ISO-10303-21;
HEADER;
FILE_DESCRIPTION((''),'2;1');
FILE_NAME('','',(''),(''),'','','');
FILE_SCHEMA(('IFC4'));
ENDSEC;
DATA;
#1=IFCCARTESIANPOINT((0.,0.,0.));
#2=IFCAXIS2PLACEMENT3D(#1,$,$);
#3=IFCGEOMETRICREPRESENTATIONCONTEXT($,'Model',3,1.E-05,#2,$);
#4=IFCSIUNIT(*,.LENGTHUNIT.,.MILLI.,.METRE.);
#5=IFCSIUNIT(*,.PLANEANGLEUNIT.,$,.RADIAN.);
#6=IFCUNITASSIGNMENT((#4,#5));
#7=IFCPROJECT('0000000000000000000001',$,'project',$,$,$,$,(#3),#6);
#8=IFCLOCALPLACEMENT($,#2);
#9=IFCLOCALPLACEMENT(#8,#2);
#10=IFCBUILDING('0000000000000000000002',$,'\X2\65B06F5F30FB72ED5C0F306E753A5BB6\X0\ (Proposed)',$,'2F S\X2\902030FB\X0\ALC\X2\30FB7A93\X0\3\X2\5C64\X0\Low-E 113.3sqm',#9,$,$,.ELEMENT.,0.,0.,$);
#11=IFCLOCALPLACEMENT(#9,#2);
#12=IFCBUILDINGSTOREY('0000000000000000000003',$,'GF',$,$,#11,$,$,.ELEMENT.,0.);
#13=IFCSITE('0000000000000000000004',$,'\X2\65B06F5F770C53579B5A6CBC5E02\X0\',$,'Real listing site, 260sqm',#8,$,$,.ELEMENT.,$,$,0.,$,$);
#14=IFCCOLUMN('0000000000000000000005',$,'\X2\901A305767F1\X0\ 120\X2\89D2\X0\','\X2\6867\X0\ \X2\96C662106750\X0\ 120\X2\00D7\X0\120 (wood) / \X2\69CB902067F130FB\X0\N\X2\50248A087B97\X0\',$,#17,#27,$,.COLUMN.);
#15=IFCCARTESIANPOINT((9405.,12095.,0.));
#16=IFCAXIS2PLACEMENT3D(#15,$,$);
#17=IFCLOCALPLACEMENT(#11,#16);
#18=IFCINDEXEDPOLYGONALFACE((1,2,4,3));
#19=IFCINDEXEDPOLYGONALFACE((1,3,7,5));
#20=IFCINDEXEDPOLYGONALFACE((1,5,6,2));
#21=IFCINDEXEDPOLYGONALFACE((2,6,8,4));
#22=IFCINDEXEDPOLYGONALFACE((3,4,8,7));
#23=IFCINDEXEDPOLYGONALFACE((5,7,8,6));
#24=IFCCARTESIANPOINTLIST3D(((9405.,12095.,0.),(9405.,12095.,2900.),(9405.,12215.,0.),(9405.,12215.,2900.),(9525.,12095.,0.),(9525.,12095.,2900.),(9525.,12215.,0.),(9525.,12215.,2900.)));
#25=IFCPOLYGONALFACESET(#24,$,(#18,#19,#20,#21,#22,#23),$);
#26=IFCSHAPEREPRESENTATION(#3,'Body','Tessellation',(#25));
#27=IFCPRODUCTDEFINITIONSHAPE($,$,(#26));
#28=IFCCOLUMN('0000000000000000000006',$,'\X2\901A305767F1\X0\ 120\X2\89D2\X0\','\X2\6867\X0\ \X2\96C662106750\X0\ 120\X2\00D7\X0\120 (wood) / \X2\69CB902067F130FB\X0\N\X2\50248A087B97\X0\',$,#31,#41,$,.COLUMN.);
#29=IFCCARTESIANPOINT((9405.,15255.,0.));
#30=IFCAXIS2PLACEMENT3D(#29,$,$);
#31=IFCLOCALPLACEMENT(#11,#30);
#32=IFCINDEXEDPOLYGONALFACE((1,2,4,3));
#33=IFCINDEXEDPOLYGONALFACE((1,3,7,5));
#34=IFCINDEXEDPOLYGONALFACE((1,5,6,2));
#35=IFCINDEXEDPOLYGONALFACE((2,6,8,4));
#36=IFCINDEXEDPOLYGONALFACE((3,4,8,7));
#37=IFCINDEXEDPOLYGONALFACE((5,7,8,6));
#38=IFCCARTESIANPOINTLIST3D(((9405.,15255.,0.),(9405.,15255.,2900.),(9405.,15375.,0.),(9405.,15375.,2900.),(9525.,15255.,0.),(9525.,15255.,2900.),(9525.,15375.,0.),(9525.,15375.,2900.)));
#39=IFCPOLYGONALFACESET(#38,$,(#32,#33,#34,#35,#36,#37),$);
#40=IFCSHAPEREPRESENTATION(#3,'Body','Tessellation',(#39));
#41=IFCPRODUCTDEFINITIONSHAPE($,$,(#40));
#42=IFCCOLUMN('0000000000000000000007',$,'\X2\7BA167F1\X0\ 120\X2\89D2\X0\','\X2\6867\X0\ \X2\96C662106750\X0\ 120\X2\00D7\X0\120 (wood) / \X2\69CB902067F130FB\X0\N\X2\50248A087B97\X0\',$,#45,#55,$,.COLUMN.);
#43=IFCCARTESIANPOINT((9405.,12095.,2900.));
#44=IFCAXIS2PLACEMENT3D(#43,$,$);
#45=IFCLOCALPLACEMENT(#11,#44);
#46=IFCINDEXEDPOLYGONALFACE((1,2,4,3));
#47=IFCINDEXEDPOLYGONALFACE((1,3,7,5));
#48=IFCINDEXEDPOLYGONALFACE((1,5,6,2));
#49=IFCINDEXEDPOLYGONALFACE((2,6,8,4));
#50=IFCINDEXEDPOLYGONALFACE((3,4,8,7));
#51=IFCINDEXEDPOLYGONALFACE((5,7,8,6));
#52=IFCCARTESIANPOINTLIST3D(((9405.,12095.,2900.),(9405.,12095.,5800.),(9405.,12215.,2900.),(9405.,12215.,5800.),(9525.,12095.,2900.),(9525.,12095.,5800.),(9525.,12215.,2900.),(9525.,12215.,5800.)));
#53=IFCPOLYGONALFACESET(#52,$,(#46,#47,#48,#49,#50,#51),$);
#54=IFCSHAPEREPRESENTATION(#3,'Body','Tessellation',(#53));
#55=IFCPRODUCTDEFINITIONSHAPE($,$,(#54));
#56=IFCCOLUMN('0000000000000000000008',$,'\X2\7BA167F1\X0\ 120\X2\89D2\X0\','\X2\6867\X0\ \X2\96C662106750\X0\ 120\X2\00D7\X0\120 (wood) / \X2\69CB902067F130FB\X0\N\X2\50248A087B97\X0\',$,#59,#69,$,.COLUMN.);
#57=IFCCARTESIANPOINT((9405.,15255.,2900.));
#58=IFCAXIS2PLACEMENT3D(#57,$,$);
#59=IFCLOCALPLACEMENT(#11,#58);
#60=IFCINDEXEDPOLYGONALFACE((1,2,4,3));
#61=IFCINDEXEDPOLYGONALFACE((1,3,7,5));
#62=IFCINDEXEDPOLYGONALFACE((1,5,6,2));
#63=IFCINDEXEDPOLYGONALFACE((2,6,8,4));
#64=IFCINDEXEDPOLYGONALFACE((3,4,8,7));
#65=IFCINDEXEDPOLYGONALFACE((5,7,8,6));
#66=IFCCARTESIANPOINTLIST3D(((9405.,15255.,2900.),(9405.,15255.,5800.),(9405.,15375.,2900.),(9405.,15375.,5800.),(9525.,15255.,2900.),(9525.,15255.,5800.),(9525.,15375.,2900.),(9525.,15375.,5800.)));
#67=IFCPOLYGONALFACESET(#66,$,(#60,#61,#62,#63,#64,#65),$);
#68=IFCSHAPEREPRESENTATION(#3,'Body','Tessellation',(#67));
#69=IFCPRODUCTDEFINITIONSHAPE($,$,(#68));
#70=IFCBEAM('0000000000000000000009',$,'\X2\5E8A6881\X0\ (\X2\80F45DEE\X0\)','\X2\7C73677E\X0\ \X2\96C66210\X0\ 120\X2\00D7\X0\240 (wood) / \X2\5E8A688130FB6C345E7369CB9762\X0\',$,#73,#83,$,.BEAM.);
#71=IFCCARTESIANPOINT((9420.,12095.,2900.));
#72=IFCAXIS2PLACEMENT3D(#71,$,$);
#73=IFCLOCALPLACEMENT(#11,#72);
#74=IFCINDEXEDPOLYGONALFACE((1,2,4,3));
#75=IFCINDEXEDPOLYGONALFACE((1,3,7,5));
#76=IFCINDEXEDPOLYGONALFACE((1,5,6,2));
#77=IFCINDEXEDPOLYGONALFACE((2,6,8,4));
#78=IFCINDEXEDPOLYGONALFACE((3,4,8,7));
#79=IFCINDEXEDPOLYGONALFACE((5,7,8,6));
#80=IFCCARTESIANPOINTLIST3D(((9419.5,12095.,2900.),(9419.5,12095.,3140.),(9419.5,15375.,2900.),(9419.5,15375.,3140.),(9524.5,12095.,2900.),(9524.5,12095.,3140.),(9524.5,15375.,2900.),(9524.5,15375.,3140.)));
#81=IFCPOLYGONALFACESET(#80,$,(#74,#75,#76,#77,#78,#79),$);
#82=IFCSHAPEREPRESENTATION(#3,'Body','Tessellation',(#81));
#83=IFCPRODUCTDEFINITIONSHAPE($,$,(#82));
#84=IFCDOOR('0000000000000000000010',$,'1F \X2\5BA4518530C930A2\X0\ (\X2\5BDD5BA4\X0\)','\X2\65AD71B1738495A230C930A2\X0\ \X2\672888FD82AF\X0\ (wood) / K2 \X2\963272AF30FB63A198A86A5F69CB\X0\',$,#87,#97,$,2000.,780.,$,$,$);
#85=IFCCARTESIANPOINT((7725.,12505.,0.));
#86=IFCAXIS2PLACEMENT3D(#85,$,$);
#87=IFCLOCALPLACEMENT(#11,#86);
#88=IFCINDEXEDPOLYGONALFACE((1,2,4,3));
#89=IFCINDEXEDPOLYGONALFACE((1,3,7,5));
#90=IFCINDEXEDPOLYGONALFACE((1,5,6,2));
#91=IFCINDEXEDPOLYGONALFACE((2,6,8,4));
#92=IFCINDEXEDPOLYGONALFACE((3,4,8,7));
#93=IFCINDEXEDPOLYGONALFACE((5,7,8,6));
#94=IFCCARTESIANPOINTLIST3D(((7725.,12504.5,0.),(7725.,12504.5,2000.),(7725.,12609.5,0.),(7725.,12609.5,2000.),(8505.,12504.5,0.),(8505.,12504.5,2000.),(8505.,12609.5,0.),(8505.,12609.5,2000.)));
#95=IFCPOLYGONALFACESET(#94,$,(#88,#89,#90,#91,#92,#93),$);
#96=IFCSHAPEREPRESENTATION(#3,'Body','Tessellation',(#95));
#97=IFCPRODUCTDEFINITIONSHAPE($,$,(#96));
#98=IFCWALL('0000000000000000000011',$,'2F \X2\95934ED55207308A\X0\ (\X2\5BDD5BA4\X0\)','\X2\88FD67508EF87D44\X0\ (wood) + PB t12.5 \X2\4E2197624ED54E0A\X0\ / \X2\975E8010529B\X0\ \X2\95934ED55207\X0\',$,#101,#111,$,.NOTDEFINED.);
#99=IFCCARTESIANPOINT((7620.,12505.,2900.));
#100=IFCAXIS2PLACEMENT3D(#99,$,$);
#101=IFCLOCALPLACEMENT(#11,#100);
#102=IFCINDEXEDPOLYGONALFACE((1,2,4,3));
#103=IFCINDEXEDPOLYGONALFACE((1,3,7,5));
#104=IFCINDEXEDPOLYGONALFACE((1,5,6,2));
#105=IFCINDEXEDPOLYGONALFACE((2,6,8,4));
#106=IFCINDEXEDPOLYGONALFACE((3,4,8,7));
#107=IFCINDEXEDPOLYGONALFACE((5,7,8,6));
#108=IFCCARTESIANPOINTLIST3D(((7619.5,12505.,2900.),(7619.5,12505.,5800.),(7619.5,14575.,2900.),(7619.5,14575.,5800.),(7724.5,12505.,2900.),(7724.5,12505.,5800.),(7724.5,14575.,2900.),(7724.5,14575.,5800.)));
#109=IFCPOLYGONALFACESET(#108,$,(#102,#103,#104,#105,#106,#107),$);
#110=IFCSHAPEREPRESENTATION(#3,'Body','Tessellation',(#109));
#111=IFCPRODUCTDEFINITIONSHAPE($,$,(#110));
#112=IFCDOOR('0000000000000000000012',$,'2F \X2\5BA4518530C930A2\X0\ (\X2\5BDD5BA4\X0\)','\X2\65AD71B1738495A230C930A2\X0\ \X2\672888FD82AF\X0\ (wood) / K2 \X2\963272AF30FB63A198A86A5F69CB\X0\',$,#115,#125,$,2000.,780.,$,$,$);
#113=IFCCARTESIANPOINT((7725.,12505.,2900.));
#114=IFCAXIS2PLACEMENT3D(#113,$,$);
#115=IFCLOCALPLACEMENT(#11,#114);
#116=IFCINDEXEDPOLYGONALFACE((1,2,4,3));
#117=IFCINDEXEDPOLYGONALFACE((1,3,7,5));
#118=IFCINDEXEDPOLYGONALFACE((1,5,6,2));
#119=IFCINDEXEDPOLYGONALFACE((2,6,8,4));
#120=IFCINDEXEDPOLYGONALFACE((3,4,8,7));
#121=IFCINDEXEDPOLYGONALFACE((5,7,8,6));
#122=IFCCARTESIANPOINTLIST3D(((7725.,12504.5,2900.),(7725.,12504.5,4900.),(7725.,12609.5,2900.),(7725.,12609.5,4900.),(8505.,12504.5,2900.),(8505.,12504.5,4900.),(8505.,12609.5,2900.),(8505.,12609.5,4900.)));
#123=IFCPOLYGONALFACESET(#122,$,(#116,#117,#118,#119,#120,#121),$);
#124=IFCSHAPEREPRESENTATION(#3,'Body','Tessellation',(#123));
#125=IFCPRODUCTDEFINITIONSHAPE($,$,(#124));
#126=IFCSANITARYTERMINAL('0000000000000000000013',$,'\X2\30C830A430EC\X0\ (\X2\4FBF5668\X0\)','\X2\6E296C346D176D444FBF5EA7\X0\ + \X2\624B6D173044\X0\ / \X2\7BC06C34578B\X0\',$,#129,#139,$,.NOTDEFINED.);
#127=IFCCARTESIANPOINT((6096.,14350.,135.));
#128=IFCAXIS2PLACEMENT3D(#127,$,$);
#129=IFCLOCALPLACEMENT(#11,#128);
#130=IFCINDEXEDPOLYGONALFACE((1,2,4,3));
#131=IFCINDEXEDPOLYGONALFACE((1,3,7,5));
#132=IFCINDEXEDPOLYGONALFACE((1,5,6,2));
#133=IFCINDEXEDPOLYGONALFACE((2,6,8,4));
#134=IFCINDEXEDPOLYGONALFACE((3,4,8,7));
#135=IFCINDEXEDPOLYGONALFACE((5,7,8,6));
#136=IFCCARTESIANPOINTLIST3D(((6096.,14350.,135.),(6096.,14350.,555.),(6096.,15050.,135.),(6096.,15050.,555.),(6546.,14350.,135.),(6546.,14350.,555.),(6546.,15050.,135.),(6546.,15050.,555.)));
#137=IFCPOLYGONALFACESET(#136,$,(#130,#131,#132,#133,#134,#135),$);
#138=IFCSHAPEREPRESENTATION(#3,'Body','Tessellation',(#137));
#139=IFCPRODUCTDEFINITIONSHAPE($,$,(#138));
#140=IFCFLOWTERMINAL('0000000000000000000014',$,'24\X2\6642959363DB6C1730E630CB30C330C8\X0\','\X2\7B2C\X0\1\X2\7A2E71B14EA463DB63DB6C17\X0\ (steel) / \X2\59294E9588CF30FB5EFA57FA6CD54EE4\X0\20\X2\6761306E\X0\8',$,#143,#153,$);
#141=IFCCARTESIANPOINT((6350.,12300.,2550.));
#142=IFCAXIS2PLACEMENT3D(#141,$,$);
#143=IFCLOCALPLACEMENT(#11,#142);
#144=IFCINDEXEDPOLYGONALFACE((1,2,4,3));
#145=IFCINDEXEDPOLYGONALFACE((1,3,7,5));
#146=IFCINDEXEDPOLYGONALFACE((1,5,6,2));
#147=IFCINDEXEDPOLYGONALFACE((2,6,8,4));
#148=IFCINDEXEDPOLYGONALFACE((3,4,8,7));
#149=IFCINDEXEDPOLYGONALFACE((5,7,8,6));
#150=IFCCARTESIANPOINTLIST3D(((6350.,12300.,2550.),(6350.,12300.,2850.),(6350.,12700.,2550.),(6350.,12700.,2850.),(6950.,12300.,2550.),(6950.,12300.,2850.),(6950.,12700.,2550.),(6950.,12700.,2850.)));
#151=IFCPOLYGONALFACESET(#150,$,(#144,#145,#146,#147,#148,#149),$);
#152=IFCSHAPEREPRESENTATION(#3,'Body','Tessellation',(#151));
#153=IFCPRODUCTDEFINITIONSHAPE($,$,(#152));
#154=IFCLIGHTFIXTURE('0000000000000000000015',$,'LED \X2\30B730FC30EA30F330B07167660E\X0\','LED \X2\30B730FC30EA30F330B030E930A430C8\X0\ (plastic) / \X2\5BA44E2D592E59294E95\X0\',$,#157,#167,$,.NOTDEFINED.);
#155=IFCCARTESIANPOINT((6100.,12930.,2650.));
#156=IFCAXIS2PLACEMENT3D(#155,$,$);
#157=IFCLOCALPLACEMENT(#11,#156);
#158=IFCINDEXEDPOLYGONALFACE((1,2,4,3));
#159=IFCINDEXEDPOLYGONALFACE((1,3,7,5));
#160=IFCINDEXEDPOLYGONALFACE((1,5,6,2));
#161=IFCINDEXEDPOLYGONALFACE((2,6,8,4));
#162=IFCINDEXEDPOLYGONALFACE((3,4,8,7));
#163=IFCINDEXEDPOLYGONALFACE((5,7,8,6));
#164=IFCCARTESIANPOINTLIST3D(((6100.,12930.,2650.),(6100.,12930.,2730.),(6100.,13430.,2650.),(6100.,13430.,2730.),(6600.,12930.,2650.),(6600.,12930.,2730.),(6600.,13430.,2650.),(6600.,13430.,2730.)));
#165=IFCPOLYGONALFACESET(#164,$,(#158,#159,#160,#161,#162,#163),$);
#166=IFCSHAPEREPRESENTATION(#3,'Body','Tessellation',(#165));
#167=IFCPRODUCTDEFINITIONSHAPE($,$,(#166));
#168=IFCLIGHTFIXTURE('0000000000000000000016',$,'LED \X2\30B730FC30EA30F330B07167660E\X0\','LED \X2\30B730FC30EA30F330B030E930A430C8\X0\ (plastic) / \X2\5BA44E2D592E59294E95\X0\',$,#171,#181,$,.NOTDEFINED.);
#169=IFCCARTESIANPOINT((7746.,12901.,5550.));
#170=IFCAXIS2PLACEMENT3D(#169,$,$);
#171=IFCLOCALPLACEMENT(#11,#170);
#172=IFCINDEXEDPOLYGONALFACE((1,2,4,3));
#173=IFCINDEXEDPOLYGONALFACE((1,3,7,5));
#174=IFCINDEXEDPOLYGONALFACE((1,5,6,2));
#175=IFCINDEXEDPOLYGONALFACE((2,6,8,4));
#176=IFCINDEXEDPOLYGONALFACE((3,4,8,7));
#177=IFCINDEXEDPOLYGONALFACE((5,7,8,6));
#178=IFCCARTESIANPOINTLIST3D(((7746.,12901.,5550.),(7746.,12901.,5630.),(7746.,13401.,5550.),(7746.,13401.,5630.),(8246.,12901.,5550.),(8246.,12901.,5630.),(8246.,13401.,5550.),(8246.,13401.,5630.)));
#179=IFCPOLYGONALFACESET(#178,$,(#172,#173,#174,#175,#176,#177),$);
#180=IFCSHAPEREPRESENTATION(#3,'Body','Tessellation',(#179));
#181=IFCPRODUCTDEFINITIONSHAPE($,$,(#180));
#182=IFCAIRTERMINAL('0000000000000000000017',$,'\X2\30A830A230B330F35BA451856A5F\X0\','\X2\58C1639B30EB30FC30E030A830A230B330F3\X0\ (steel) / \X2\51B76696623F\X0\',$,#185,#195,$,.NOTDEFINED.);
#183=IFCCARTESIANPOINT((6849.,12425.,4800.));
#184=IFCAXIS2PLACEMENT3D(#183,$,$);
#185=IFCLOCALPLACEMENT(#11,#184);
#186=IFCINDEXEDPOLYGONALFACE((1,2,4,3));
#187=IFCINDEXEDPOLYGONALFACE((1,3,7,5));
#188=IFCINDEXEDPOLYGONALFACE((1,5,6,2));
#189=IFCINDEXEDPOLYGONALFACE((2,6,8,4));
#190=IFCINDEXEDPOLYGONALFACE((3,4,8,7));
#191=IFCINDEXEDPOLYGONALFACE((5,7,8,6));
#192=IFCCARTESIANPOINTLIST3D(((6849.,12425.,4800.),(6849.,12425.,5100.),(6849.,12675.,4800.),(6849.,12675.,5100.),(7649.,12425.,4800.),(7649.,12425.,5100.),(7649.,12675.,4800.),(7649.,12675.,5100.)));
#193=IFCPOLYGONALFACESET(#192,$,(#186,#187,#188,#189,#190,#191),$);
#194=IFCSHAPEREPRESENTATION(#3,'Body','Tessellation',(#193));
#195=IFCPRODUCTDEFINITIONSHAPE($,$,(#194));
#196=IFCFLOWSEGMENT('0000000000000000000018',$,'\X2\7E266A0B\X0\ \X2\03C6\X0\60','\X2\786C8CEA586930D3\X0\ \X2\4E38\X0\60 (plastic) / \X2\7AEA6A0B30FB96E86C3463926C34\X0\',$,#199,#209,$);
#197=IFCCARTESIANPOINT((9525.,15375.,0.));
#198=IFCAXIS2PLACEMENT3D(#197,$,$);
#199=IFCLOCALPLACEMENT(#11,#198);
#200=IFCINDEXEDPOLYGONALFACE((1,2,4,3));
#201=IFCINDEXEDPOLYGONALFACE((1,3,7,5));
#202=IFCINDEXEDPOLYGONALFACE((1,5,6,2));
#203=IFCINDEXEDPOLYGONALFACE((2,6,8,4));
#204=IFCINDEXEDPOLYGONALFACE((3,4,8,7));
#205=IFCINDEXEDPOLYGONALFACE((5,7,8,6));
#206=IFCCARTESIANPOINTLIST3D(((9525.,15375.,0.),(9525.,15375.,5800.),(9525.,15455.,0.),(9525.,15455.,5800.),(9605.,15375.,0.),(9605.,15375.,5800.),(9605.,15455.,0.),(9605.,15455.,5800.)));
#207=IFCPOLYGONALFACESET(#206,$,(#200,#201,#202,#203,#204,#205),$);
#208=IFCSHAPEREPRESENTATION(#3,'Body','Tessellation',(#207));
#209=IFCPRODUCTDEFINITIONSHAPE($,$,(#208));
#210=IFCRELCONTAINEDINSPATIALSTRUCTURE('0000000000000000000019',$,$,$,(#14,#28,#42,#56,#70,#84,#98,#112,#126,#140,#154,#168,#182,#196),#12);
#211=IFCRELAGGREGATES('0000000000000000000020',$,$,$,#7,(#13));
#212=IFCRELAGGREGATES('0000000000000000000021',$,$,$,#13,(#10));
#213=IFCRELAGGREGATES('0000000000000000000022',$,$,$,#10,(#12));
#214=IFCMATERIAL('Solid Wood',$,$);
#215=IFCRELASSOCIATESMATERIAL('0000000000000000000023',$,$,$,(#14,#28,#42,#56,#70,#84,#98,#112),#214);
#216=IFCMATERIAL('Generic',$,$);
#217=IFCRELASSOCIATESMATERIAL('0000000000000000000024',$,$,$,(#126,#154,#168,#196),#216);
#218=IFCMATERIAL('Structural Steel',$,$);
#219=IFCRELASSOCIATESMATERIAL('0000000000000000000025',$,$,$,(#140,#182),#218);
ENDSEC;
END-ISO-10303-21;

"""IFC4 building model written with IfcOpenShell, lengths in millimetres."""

from ifc_helpers import new_model, si_unit, frame, frame_2d, origin, place, context, project, spatial, rectangle, extrude, material, element, save


model = new_model("IFC4")

# Units and contexts
model_context = context("Model", 3, precision=1e-05, world=origin())
ifc_project = project(units=[si_unit("LENGTHUNIT", "METRE", prefix="MILLI"), si_unit("PLANEANGLEUNIT", "RADIAN")], contexts=[model_context])

# Site, building, storey
site_placement = place(None, origin())
site = spatial("IfcSite", under=ifc_project, at=site_placement, Name="新潟県南魚沼市", ObjectType="Real listing site, 260sqm", CompositionType="ELEMENT", RefElevation=0.0)
building_placement = place(site_placement, origin())
building = spatial("IfcBuilding", under=site, at=building_placement, Name="新潟・狭小の町家 (Proposed)", ObjectType="2F S造・ALC・窓3層Low-E 113.3sqm", CompositionType="ELEMENT", ElevationOfRefHeight=0.0, ElevationOfTerrain=0.0)
storey_placement = place(building_placement, origin())
storey = spatial("IfcBuildingStorey", under=building, at=storey_placement, Name="GF", CompositionType="ELEMENT", Elevation=0.0)

# Columns
ifc_material_1 = material(Name="Solid Wood")
column_1_placement = place(storey_placement, frame((9405.0, 12095.0, 0.0)))
element("IfcColumn", 1, at=column_1_placement, inside=storey, material=ifc_material_1, Name="通し柱 120角", Description="桧 集成材 120×120 (wood) / 構造柱・N値計算", PredefinedType="COLUMN", context=model_context, shape_type="SweptSolid", body=[
    extrude(rectangle(XDim=120.0, YDim=120.0, at=frame_2d((60.0, 60.0))), frame((9405.0, 12095.0, 0.0)), (0.0, 0.0, 1.0), 2900.0),
])
column_2_placement = place(storey_placement, frame((9405.0, 15255.0, 0.0)))
element("IfcColumn", 2, at=column_2_placement, inside=storey, material=ifc_material_1, Name="通し柱 120角", Description="桧 集成材 120×120 (wood) / 構造柱・N値計算", PredefinedType="COLUMN", context=model_context, shape_type="SweptSolid", body=[
    extrude(rectangle(XDim=120.0, YDim=120.0, at=frame_2d((60.0, 60.0))), frame((9405.0, 15255.0, 0.0)), (0.0, 0.0, 1.0), 2900.0),
])
column_3_placement = place(storey_placement, frame((9405.0, 12095.0, 2900.0)))
element("IfcColumn", 3, at=column_3_placement, inside=storey, material=ifc_material_1, Name="管柱 120角", Description="桧 集成材 120×120 (wood) / 構造柱・N値計算", PredefinedType="COLUMN", context=model_context, shape_type="SweptSolid", body=[
    extrude(rectangle(XDim=120.0, YDim=120.0, at=frame_2d((60.0, 60.0))), frame((9405.0, 12095.0, 2900.0)), (0.0, 0.0, 1.0), 2900.0),
])
column_4_placement = place(storey_placement, frame((9405.0, 15255.0, 2900.0)))
element("IfcColumn", 4, at=column_4_placement, inside=storey, material=ifc_material_1, Name="管柱 120角", Description="桧 集成材 120×120 (wood) / 構造柱・N値計算", PredefinedType="COLUMN", context=model_context, shape_type="SweptSolid", body=[
    extrude(rectangle(XDim=120.0, YDim=120.0, at=frame_2d((60.0, 60.0))), frame((9405.0, 15255.0, 2900.0)), (0.0, 0.0, 1.0), 2900.0),
])

# Beam
beam_1_placement = place(storey_placement, frame((9420.0, 12095.0, 2900.0)))
element("IfcBeam", 5, at=beam_1_placement, inside=storey, material=ifc_material_1, Name="床梁 (胴差)", Description="米松 集成 120×240 (wood) / 床梁・水平構面", PredefinedType="BEAM", context=model_context, shape_type="SweptSolid", body=[
    extrude(rectangle(XDim=105.0, YDim=3280.0, at=frame_2d((52.0, 1640.0))), frame((9420.0, 12095.0, 2900.0)), (0.0, 0.0, 1.0), 240.0),
])

# Door
door_1_placement = place(storey_placement, frame((7725.0, 12505.0, 0.0)))
element("IfcDoor", 6, at=door_1_placement, inside=storey, material=ifc_material_1, Name="1F 室内ドア (寝室)", Description="断熱玄関ドア 木製芯 (wood) / K2 防犯・採風機構", OverallHeight=2000.0, OverallWidth=780.0, context=model_context, shape_type="SweptSolid", body=[
    extrude(rectangle(XDim=780.0, YDim=105.0, at=frame_2d((390.0, 52.0))), frame((7725.0, 12505.0, 0.0)), (0.0, 0.0, 1.0), 2000.0),
])

# Wall
wall_1_placement = place(storey_placement, frame((7620.0, 12505.0, 2900.0)))
element("IfcWall", 7, at=wall_1_placement, inside=storey, material=ifc_material_1, Name="2F 間仕切り (寝室)", Description="製材軸組 (wood) + PB t12.5 両面仕上 / 非耐力 間仕切", PredefinedType="NOTDEFINED", context=model_context, shape_type="SweptSolid", body=[
    extrude(rectangle(XDim=105.0, YDim=2070.0, at=frame_2d((52.0, 1035.0))), frame((7620.0, 12505.0, 2900.0)), (0.0, 0.0, 1.0), 2900.0),
])

# Door
door_2_placement = place(storey_placement, frame((7725.0, 12505.0, 2900.0)))
element("IfcDoor", 8, at=door_2_placement, inside=storey, material=ifc_material_1, Name="2F 室内ドア (寝室)", Description="断熱玄関ドア 木製芯 (wood) / K2 防犯・採風機構", OverallHeight=2000.0, OverallWidth=780.0, context=model_context, shape_type="SweptSolid", body=[
    extrude(rectangle(XDim=780.0, YDim=105.0, at=frame_2d((390.0, 52.0))), frame((7725.0, 12505.0, 2900.0)), (0.0, 0.0, 1.0), 2000.0),
])

# Sanitary terminal
ifc_material_2 = material(Name="Generic")
sanitary_terminal_placement = place(storey_placement, frame((6096.0, 14350.0, 135.0)))
element("IfcSanitaryTerminal", 9, at=sanitary_terminal_placement, inside=storey, material=ifc_material_2, Name="トイレ (便器)", Description="温水洗浄便座 + 手洗い / 節水型", PredefinedType="NOTDEFINED", context=model_context, shape_type="SweptSolid", body=[
    extrude(rectangle(XDim=450.0, YDim=700.0, at=frame_2d((225.0, 350.0))), frame((6096.0, 14350.0, 135.0)), (0.0, 0.0, 1.0), 420.0),
])

# Flow terminal
ifc_material_3 = material(Name="Structural Steel")
flow_terminal_placement = place(storey_placement, frame((6350.0, 12300.0, 2550.0)))
element("IfcFlowTerminal", 10, at=flow_terminal_placement, inside=storey, material=ifc_material_3, Name="24時間換気ユニット", Description="第1種熱交換換気 (steel) / 天井裏・建基法令20条の8", context=model_context, shape_type="SweptSolid", body=[
    extrude(rectangle(XDim=600.0, YDim=400.0, at=frame_2d((300.0, 200.0))), frame((6350.0, 12300.0, 2550.0)), (0.0, 0.0, 1.0), 300.0),
])

# Light fixtures
light_fixture_1_placement = place(storey_placement, frame((6100.0, 12930.0, 2650.0)))
element("IfcLightFixture", 11, at=light_fixture_1_placement, inside=storey, material=ifc_material_2, Name="LED シーリング照明", Description="LED シーリングライト (plastic) / 室中央天井", PredefinedType="NOTDEFINED", context=model_context, shape_type="SweptSolid", body=[
    extrude(rectangle(XDim=500.0, YDim=500.0, at=frame_2d((250.0, 250.0))), frame((6100.0, 12930.0, 2650.0)), (0.0, 0.0, 1.0), 80.0),
])
light_fixture_2_placement = place(storey_placement, frame((7746.0, 12901.0, 5550.0)))
element("IfcLightFixture", 12, at=light_fixture_2_placement, inside=storey, material=ifc_material_2, Name="LED シーリング照明", Description="LED シーリングライト (plastic) / 室中央天井", PredefinedType="NOTDEFINED", context=model_context, shape_type="SweptSolid", body=[
    extrude(rectangle(XDim=500.0, YDim=500.0, at=frame_2d((250.0, 250.0))), frame((7746.0, 12901.0, 5550.0)), (0.0, 0.0, 1.0), 80.0),
])

# Air terminal
air_terminal_placement = place(storey_placement, frame((6849.0, 12425.0, 4800.0)))
element("IfcAirTerminal", 13, at=air_terminal_placement, inside=storey, material=ifc_material_3, Name="エアコン室内機", Description="壁掛ルームエアコン (steel) / 冷暖房", PredefinedType="NOTDEFINED", context=model_context, shape_type="SweptSolid", body=[
    extrude(rectangle(XDim=800.0, YDim=250.0, at=frame_2d((400.0, 125.0))), frame((6849.0, 12425.0, 4800.0)), (0.0, 0.0, 1.0), 300.0),
])

# Flow segment
flow_segment_placement = place(storey_placement, frame((9525.0, 15375.0, 0.0)))
element("IfcFlowSegment", 14, at=flow_segment_placement, inside=storey, material=ifc_material_2, Name="縦樋 φ60", Description="硬質塩ビ 丸60 (plastic) / 竪樋・雨水排水", context=model_context, shape_type="SweptSolid", body=[
    extrude(rectangle(XDim=80.0, YDim=80.0, at=frame_2d((40.0, 40.0))), frame((9525.0, 15375.0, 0.0)), (0.0, 0.0, 1.0), 5800.0),
])

save(model, "model.ifc")
